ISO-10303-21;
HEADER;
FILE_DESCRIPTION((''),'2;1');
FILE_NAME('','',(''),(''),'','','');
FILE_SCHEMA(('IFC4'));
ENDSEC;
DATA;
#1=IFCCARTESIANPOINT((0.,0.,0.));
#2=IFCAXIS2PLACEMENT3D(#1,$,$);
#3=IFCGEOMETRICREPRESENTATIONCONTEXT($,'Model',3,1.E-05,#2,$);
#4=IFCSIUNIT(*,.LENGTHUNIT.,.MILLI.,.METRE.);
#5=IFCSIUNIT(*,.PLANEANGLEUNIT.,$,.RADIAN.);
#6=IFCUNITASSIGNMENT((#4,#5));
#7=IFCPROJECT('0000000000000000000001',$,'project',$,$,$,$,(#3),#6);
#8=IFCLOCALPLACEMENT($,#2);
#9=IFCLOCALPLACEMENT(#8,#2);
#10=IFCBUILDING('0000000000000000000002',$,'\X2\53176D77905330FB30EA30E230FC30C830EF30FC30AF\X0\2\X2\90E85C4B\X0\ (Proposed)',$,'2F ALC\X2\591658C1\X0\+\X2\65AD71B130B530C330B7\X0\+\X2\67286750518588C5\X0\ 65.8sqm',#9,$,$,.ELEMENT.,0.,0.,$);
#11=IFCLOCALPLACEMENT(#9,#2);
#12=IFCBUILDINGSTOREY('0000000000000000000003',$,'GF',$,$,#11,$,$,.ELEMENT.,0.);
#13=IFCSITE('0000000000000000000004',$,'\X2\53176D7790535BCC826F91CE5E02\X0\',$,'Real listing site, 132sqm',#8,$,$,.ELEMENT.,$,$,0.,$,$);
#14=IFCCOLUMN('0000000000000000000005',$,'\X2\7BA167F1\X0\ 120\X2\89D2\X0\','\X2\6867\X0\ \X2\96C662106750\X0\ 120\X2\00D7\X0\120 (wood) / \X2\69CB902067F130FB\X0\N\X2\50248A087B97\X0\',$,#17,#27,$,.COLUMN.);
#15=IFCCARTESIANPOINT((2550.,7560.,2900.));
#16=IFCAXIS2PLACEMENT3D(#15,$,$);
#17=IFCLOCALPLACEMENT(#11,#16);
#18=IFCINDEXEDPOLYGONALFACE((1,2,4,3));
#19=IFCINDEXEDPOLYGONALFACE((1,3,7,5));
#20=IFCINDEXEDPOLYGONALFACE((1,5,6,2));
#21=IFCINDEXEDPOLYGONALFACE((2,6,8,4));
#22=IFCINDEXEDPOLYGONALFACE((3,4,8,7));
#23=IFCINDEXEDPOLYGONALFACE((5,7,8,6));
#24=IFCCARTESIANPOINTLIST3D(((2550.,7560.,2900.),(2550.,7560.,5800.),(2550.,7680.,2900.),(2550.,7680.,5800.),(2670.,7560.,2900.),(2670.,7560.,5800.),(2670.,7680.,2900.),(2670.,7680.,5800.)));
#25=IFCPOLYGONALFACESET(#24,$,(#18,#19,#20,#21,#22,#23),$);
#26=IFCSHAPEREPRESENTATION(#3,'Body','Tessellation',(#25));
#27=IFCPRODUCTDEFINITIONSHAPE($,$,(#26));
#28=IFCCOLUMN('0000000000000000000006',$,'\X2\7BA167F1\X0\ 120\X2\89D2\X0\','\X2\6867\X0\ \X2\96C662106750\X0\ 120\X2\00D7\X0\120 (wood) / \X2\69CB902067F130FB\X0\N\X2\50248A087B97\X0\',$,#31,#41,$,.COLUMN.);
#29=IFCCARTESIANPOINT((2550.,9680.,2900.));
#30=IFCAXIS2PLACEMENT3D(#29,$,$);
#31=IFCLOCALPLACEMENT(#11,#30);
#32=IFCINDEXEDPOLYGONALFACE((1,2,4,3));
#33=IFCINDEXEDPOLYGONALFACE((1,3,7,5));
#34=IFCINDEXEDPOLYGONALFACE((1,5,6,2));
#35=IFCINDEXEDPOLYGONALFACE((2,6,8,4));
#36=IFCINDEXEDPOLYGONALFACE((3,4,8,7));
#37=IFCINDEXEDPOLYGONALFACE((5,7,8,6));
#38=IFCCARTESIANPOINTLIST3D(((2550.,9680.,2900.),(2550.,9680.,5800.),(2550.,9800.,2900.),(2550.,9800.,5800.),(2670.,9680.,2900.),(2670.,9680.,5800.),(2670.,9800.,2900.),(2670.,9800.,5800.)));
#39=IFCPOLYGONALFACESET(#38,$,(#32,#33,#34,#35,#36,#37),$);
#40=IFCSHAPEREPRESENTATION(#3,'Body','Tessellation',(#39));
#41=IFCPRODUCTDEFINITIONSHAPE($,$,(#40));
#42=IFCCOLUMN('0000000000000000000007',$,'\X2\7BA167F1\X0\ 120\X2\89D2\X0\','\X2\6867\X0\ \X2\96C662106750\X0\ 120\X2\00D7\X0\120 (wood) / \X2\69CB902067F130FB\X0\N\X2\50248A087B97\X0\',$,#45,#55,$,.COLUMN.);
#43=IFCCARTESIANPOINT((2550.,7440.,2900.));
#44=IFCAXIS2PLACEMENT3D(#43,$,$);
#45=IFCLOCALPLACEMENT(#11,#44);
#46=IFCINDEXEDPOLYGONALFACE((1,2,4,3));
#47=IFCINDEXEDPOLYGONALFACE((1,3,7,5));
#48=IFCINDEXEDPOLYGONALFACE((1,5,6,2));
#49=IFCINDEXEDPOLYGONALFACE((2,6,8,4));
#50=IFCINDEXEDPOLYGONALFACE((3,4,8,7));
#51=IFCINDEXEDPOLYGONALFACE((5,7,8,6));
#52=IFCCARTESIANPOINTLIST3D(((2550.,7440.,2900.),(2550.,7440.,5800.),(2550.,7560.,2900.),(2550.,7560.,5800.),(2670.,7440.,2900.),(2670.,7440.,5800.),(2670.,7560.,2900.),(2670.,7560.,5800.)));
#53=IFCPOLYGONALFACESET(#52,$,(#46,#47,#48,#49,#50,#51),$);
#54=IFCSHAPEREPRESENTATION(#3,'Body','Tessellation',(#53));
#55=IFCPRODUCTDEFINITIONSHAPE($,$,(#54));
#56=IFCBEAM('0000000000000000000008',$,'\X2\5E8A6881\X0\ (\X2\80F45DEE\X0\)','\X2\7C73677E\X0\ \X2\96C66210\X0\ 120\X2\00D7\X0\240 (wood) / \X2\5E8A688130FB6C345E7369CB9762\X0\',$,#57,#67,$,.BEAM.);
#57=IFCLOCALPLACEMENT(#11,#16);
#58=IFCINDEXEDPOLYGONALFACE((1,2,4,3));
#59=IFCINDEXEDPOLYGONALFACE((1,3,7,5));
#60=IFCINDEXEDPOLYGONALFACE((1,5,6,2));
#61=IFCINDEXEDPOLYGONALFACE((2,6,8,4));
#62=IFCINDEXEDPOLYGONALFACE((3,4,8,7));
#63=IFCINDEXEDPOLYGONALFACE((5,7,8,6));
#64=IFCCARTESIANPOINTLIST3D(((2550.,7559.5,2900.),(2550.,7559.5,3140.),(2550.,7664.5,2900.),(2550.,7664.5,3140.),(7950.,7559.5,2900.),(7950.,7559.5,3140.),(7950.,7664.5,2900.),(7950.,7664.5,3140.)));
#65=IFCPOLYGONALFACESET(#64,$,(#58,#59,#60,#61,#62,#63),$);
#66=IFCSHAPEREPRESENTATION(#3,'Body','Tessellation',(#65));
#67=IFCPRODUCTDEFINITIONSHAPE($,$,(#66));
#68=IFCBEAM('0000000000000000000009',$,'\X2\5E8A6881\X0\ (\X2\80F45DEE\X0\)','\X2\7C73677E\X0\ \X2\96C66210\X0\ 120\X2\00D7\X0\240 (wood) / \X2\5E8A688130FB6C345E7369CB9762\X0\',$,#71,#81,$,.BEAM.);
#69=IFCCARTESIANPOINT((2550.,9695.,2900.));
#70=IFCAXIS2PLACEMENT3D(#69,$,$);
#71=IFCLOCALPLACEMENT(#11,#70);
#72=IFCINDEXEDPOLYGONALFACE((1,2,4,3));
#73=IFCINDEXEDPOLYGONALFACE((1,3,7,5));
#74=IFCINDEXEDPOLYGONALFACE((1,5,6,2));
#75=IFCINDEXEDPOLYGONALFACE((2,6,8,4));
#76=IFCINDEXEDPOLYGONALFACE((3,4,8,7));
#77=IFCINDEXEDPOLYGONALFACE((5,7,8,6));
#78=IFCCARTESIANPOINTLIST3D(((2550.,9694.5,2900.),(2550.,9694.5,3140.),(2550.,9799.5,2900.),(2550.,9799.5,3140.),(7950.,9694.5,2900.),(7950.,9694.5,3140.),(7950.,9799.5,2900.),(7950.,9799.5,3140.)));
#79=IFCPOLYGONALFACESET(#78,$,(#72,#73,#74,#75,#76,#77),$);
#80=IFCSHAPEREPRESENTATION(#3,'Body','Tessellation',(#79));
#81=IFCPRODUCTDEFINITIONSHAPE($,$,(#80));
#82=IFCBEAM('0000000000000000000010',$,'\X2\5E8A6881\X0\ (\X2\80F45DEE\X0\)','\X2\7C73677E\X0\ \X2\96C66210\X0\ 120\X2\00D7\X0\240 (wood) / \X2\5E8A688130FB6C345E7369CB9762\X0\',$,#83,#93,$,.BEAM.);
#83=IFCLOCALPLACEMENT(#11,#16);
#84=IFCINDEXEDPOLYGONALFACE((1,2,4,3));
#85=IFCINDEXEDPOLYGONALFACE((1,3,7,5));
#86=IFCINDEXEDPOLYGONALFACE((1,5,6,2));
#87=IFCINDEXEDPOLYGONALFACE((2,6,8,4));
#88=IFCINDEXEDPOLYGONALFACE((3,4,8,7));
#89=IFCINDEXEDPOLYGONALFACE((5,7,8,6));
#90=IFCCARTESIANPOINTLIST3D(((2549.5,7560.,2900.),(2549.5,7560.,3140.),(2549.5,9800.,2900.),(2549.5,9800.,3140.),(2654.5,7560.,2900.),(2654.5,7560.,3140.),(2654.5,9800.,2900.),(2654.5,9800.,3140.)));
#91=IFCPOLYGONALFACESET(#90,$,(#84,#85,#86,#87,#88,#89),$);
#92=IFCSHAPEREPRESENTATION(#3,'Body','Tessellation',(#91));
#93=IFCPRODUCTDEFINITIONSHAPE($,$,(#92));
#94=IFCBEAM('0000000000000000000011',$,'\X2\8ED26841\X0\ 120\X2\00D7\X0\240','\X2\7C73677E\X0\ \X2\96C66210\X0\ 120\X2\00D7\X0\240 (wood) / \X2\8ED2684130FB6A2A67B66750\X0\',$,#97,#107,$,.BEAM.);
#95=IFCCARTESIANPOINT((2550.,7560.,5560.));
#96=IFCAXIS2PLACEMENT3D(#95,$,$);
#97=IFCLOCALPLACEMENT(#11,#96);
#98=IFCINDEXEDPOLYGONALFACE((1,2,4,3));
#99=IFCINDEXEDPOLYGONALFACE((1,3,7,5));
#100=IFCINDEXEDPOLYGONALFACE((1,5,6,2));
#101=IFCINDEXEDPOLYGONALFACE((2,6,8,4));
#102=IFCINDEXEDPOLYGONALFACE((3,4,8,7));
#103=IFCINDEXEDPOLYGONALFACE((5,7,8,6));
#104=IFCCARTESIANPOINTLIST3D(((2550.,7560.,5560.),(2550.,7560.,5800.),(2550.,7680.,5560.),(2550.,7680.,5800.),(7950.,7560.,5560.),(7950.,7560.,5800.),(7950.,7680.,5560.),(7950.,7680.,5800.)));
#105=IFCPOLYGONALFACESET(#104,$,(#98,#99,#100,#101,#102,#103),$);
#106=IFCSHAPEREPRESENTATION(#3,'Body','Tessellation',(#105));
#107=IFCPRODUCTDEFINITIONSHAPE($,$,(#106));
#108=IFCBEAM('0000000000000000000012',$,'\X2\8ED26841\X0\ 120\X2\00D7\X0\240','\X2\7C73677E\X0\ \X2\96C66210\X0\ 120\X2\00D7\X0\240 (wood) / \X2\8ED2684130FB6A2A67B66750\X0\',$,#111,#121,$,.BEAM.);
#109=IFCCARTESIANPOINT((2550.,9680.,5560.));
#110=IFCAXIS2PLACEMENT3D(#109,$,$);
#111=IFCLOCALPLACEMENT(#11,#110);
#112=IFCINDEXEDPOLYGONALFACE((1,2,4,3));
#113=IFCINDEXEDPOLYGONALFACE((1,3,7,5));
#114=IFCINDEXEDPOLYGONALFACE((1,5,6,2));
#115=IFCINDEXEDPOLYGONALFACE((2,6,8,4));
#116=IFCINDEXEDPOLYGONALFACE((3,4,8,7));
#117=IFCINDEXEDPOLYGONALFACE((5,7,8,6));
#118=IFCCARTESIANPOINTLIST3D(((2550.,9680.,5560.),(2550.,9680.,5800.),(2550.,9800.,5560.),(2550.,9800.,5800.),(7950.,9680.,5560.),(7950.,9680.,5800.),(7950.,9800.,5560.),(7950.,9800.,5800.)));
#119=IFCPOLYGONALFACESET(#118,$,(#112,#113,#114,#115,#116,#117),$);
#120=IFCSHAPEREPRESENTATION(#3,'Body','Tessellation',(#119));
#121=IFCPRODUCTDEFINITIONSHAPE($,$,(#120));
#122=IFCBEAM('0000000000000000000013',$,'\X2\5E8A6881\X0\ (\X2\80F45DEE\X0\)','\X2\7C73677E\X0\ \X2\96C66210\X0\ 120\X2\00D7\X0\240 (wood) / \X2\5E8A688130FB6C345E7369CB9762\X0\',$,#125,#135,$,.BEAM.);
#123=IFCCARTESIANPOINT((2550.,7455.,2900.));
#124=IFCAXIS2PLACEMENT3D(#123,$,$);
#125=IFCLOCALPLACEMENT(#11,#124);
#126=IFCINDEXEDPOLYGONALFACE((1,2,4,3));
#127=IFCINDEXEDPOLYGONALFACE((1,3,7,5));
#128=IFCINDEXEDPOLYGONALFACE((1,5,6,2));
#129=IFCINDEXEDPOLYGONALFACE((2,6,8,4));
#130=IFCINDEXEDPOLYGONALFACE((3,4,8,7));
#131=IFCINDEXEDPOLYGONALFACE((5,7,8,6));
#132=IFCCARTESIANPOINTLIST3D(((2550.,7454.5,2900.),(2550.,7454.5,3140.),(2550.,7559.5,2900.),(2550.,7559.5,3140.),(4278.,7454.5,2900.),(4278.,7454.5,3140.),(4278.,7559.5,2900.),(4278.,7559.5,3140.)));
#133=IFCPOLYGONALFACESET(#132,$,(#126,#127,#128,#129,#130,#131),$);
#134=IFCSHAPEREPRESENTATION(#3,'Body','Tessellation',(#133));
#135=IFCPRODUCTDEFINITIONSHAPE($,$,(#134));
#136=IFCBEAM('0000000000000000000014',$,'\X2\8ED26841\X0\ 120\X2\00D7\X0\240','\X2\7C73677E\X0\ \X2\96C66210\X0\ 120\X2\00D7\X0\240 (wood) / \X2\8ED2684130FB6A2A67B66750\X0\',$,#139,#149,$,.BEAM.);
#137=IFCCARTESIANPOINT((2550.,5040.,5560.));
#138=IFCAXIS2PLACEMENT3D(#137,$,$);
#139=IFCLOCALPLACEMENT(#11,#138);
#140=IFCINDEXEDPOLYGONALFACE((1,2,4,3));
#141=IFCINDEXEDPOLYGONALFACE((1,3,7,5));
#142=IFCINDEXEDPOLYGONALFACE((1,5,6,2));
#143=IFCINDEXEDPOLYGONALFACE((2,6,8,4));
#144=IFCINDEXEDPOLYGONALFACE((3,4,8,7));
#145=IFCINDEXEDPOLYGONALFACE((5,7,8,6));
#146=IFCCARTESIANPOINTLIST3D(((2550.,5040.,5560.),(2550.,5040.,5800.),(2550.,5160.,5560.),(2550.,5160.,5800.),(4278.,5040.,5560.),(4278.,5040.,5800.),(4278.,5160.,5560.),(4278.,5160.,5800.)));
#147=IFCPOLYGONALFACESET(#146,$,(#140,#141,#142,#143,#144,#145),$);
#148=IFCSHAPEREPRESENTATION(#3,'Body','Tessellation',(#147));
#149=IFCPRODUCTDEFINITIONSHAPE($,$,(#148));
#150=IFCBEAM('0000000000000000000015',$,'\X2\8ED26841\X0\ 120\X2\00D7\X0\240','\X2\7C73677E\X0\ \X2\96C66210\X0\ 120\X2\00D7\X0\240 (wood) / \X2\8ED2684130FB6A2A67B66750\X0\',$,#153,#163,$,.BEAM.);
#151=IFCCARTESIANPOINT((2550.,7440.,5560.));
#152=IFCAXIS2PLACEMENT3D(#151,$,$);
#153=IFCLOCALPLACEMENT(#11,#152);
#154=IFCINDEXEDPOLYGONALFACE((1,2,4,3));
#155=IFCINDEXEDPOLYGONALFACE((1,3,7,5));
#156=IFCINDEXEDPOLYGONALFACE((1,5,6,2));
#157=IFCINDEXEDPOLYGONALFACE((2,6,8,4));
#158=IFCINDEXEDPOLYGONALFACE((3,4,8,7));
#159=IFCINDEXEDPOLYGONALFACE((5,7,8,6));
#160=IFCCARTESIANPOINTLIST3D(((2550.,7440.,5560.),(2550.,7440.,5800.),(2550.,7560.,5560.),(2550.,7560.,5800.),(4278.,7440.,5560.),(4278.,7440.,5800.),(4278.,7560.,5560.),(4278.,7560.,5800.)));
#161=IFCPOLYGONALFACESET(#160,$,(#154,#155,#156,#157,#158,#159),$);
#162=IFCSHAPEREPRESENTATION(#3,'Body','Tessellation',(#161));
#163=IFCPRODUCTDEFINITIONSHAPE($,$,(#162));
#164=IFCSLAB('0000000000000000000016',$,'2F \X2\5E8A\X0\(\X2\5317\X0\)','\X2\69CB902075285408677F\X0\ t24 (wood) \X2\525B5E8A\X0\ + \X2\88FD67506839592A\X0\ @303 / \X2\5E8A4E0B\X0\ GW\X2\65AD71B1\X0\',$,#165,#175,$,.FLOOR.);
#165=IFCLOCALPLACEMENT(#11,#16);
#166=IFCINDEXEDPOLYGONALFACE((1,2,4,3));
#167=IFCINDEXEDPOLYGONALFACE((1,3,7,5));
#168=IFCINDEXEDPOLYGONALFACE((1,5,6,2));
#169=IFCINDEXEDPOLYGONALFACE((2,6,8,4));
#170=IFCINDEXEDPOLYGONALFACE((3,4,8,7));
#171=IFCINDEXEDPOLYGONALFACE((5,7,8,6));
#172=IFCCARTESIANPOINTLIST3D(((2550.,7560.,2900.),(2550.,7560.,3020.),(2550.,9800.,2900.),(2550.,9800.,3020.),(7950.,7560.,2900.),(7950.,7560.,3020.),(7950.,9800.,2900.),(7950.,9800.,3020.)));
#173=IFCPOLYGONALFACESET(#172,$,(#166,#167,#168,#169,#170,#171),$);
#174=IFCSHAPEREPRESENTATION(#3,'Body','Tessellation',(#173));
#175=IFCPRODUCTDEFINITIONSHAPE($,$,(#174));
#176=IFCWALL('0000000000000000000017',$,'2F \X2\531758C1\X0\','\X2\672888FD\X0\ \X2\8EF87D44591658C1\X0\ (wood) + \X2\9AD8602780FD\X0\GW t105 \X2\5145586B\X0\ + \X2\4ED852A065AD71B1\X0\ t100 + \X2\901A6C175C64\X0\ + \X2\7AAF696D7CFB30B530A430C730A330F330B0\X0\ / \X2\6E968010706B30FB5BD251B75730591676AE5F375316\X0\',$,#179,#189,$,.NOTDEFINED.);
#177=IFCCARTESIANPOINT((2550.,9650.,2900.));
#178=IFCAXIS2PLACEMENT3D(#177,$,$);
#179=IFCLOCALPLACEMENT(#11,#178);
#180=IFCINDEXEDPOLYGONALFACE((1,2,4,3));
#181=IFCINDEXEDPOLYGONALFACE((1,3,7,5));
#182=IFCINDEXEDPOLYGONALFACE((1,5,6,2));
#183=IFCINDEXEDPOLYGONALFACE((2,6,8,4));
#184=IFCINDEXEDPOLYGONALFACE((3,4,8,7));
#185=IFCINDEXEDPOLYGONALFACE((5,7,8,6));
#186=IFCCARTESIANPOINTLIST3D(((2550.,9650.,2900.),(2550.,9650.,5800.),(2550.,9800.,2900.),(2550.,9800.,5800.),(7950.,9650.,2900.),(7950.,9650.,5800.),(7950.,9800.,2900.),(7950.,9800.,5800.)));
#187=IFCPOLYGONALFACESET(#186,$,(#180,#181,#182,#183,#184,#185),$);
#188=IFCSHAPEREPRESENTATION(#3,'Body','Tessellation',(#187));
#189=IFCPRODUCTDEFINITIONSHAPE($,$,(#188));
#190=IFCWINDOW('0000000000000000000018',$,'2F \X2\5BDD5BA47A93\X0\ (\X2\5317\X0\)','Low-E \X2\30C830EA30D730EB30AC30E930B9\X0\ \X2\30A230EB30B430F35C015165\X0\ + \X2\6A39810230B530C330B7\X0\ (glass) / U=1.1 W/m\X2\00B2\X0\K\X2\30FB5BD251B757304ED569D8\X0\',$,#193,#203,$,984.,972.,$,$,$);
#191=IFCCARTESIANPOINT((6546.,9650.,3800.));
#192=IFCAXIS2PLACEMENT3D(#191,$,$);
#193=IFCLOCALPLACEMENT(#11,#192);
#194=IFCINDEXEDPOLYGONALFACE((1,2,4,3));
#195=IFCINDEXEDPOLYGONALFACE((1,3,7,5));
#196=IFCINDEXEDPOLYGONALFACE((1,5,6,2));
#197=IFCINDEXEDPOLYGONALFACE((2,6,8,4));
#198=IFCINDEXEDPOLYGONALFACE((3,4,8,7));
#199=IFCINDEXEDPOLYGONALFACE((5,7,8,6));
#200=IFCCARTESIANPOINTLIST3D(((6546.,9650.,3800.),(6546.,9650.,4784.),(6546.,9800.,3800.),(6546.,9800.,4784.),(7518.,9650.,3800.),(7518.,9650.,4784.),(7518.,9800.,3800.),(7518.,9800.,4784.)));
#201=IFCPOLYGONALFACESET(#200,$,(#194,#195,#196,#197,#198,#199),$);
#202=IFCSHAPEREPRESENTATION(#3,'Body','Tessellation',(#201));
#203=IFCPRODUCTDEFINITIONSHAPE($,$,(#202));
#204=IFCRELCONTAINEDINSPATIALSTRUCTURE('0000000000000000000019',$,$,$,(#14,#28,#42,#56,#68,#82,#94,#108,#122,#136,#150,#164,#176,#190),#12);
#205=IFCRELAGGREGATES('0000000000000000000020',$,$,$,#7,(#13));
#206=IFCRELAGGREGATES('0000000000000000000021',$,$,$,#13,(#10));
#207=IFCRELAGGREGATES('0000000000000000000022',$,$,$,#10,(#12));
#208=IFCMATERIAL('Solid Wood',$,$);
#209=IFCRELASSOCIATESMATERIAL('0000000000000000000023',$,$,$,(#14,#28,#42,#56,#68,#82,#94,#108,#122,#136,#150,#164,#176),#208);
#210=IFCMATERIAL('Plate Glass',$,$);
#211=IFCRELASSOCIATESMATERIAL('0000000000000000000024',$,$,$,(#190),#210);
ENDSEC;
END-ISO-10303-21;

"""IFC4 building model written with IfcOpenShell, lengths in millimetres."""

from ifc_helpers import new_model, si_unit, frame, frame_2d, origin, place, context, project, spatial, rectangle, extrude, material, element, fill, save


model = new_model("IFC4")

# Units and contexts
model_context = context("Model", 3, precision=1e-05, world=origin())
ifc_project = project(units=[si_unit("LENGTHUNIT", "METRE", prefix="MILLI"), si_unit("PLANEANGLEUNIT", "RADIAN")], contexts=[model_context])

# Site, building, storey
site_placement = place(None, origin())
site = spatial("IfcSite", under=ifc_project, at=site_placement, Name="北海道富良野市", ObjectType="Real listing site, 132sqm", CompositionType="ELEMENT", RefElevation=0.0)
building_placement = place(site_placement, origin())
building = spatial("IfcBuilding", under=site, at=building_placement, Name="北海道・リモートワーク2部屋 (Proposed)", ObjectType="2F ALC外壁+断熱サッシ+木材内装 65.8sqm", CompositionType="ELEMENT", ElevationOfRefHeight=0.0, ElevationOfTerrain=0.0)
storey_placement = place(building_placement, origin())
storey = spatial("IfcBuildingStorey", under=building, at=storey_placement, Name="GF", CompositionType="ELEMENT", Elevation=0.0)

# Columns
ifc_material_1 = material(Name="Solid Wood")
column_1_placement = place(storey_placement, frame((2550.0, 7560.0, 2900.0)))
element("IfcColumn", 1, at=column_1_placement, inside=storey, material=ifc_material_1, Name="管柱 120角", Description="桧 集成材 120×120 (wood) / 構造柱・N値計算", PredefinedType="COLUMN", context=model_context, shape_type="SweptSolid", body=[
    extrude(rectangle(XDim=120.0, YDim=120.0, at=frame_2d((60.0, 60.0))), frame((2550.0, 7560.0, 2900.0)), (0.0, 0.0, 1.0), 2900.0),
])
column_2_placement = place(storey_placement, frame((2550.0, 9680.0, 2900.0)))
element("IfcColumn", 2, at=column_2_placement, inside=storey, material=ifc_material_1, Name="管柱 120角", Description="桧 集成材 120×120 (wood) / 構造柱・N値計算", PredefinedType="COLUMN", context=model_context, shape_type="SweptSolid", body=[
    extrude(rectangle(XDim=120.0, YDim=120.0, at=frame_2d((60.0, 60.0))), frame((2550.0, 9680.0, 2900.0)), (0.0, 0.0, 1.0), 2900.0),
])
column_3_placement = place(storey_placement, frame((2550.0, 7440.0, 2900.0)))
element("IfcColumn", 3, at=column_3_placement, inside=storey, material=ifc_material_1, Name="管柱 120角", Description="桧 集成材 120×120 (wood) / 構造柱・N値計算", PredefinedType="COLUMN", context=model_context, shape_type="SweptSolid", body=[
    extrude(rectangle(XDim=120.0, YDim=120.0, at=frame_2d((60.0, 60.0))), frame((2550.0, 7440.0, 2900.0)), (0.0, 0.0, 1.0), 2900.0),
])

# Beams
beam_1_placement = place(storey_placement, frame((2550.0, 7560.0, 2900.0)))
element("IfcBeam", 4, at=beam_1_placement, inside=storey, material=ifc_material_1, Name="床梁 (胴差)", Description="米松 集成 120×240 (wood) / 床梁・水平構面", PredefinedType="BEAM", context=model_context, shape_type="SweptSolid", body=[
    extrude(rectangle(XDim=5400.0, YDim=105.0, at=frame_2d((2700.0, 52.0))), frame((2550.0, 7560.0, 2900.0)), (0.0, 0.0, 1.0), 240.0),
])
beam_2_placement = place(storey_placement, frame((2550.0, 9695.0, 2900.0)))
element("IfcBeam", 5, at=beam_2_placement, inside=storey, material=ifc_material_1, Name="床梁 (胴差)", Description="米松 集成 120×240 (wood) / 床梁・水平構面", PredefinedType="BEAM", context=model_context, shape_type="SweptSolid", body=[
    extrude(rectangle(XDim=5400.0, YDim=105.0, at=frame_2d((2700.0, 52.0))), frame((2550.0, 9695.0, 2900.0)), (0.0, 0.0, 1.0), 240.0),
])
beam_3_placement = place(storey_placement, frame((2550.0, 7560.0, 2900.0)))
element("IfcBeam", 6, at=beam_3_placement, inside=storey, material=ifc_material_1, Name="床梁 (胴差)", Description="米松 集成 120×240 (wood) / 床梁・水平構面", PredefinedType="BEAM", context=model_context, shape_type="SweptSolid", body=[
    extrude(rectangle(XDim=105.0, YDim=2240.0, at=frame_2d((52.0, 1120.0))), frame((2550.0, 7560.0, 2900.0)), (0.0, 0.0, 1.0), 240.0),
])
beam_4_placement = place(storey_placement, frame((2550.0, 7560.0, 5560.0)))
element("IfcBeam", 7, at=beam_4_placement, inside=storey, material=ifc_material_1, Name="軒桁 120×240", Description="米松 集成 120×240 (wood) / 軒桁・横架材", PredefinedType="BEAM", context=model_context, shape_type="SweptSolid", body=[
    extrude(rectangle(XDim=5400.0, YDim=120.0, at=frame_2d((2700.0, 60.0))), frame((2550.0, 7560.0, 5560.0)), (0.0, 0.0, 1.0), 240.0),
])
beam_5_placement = place(storey_placement, frame((2550.0, 9680.0, 5560.0)))
element("IfcBeam", 8, at=beam_5_placement, inside=storey, material=ifc_material_1, Name="軒桁 120×240", Description="米松 集成 120×240 (wood) / 軒桁・横架材", PredefinedType="BEAM", context=model_context, shape_type="SweptSolid", body=[
    extrude(rectangle(XDim=5400.0, YDim=120.0, at=frame_2d((2700.0, 60.0))), frame((2550.0, 9680.0, 5560.0)), (0.0, 0.0, 1.0), 240.0),
])
beam_6_placement = place(storey_placement, frame((2550.0, 7455.0, 2900.0)))
element("IfcBeam", 9, at=beam_6_placement, inside=storey, material=ifc_material_1, Name="床梁 (胴差)", Description="米松 集成 120×240 (wood) / 床梁・水平構面", PredefinedType="BEAM", context=model_context, shape_type="SweptSolid", body=[
    extrude(rectangle(XDim=1728.0, YDim=105.0, at=frame_2d((864.0, 52.0))), frame((2550.0, 7455.0, 2900.0)), (0.0, 0.0, 1.0), 240.0),
])
beam_7_placement = place(storey_placement, frame((2550.0, 5040.0, 5560.0)))
element("IfcBeam", 10, at=beam_7_placement, inside=storey, material=ifc_material_1, Name="軒桁 120×240", Description="米松 集成 120×240 (wood) / 軒桁・横架材", PredefinedType="BEAM", context=model_context, shape_type="SweptSolid", body=[
    extrude(rectangle(XDim=1728.0, YDim=120.0, at=frame_2d((864.0, 60.0))), frame((2550.0, 5040.0, 5560.0)), (0.0, 0.0, 1.0), 240.0),
])
beam_8_placement = place(storey_placement, frame((2550.0, 7440.0, 5560.0)))
element("IfcBeam", 11, at=beam_8_placement, inside=storey, material=ifc_material_1, Name="軒桁 120×240", Description="米松 集成 120×240 (wood) / 軒桁・横架材", PredefinedType="BEAM", context=model_context, shape_type="SweptSolid", body=[
    extrude(rectangle(XDim=1728.0, YDim=120.0, at=frame_2d((864.0, 60.0))), frame((2550.0, 7440.0, 5560.0)), (0.0, 0.0, 1.0), 240.0),
])

# Slab
slab_placement = place(storey_placement, frame((2550.0, 7560.0, 2900.0)))
element("IfcSlab", 12, at=slab_placement, inside=storey, material=ifc_material_1, Name="2F 床(北)", Description="構造用合板 t24 (wood) 剛床 + 製材根太 @303 / 床下 GW断熱", PredefinedType="FLOOR", context=model_context, shape_type="SweptSolid", body=[
    extrude(rectangle(XDim=5400.0, YDim=2240.0, at=frame_2d((2700.0, 1120.0))), frame((2550.0, 7560.0, 2900.0)), (0.0, 0.0, 1.0), 120.0),
])

# Wall, opening, window
wall_placement = place(storey_placement, frame((2550.0, 9650.0, 2900.0)))
wall = element("IfcWall", 13, at=wall_placement, inside=storey, material=ifc_material_1, Name="2F 北壁", Description="木製 軸組外壁 (wood) + 高性能GW t105 充填 + 付加断熱 t100 + 通気層 + 窯業系サイディング / 準耐火・寒冷地外皮強化", PredefinedType="NOTDEFINED", context=model_context, shape_type="SweptSolid", body=[
    extrude(rectangle(XDim=5400.0, YDim=150.0, at=frame_2d((2700.0, 75.0))), frame((2550.0, 9650.0, 2900.0)), (0.0, 0.0, 1.0), 2900.0),
])
opening_placement = place(storey_placement, frame((6546.0, 9650.0, 3800.0)))
opening = element("IfcOpeningElement", 14, at=opening_placement, cuts=wall, PredefinedType="NOTDEFINED", context=model_context, shape_type="SweptSolid", body=[
    extrude(rectangle(XDim=972.0, YDim=150.0, at=frame_2d((486.0, 75.0))), frame((6546.0, 9650.0, 3800.0)), (0.0, 0.0, 1.0), 984.0),
])
ifc_material_2 = material(Name="Plate Glass")
window_placement = place(storey_placement, frame((6546.0, 9650.0, 3800.0)))
window = element("IfcWindow", 15, at=window_placement, inside=storey, material=ifc_material_2, Name="2F 寝室窓 (北)", Description="Low-E トリプルガラス アルゴン封入 + 樹脂サッシ (glass) / U=1.1 W/m²K・寒冷地仕様", OverallHeight=984.0, OverallWidth=972.0, context=model_context, shape_type="SweptSolid", body=[
    extrude(rectangle(XDim=972.0, YDim=150.0, at=frame_2d((486.0, 75.0))), frame((6546.0, 9650.0, 3800.0)), (0.0, 0.0, 1.0), 984.0),
])
fill(opening, window)

save(model, "model.ifc")
